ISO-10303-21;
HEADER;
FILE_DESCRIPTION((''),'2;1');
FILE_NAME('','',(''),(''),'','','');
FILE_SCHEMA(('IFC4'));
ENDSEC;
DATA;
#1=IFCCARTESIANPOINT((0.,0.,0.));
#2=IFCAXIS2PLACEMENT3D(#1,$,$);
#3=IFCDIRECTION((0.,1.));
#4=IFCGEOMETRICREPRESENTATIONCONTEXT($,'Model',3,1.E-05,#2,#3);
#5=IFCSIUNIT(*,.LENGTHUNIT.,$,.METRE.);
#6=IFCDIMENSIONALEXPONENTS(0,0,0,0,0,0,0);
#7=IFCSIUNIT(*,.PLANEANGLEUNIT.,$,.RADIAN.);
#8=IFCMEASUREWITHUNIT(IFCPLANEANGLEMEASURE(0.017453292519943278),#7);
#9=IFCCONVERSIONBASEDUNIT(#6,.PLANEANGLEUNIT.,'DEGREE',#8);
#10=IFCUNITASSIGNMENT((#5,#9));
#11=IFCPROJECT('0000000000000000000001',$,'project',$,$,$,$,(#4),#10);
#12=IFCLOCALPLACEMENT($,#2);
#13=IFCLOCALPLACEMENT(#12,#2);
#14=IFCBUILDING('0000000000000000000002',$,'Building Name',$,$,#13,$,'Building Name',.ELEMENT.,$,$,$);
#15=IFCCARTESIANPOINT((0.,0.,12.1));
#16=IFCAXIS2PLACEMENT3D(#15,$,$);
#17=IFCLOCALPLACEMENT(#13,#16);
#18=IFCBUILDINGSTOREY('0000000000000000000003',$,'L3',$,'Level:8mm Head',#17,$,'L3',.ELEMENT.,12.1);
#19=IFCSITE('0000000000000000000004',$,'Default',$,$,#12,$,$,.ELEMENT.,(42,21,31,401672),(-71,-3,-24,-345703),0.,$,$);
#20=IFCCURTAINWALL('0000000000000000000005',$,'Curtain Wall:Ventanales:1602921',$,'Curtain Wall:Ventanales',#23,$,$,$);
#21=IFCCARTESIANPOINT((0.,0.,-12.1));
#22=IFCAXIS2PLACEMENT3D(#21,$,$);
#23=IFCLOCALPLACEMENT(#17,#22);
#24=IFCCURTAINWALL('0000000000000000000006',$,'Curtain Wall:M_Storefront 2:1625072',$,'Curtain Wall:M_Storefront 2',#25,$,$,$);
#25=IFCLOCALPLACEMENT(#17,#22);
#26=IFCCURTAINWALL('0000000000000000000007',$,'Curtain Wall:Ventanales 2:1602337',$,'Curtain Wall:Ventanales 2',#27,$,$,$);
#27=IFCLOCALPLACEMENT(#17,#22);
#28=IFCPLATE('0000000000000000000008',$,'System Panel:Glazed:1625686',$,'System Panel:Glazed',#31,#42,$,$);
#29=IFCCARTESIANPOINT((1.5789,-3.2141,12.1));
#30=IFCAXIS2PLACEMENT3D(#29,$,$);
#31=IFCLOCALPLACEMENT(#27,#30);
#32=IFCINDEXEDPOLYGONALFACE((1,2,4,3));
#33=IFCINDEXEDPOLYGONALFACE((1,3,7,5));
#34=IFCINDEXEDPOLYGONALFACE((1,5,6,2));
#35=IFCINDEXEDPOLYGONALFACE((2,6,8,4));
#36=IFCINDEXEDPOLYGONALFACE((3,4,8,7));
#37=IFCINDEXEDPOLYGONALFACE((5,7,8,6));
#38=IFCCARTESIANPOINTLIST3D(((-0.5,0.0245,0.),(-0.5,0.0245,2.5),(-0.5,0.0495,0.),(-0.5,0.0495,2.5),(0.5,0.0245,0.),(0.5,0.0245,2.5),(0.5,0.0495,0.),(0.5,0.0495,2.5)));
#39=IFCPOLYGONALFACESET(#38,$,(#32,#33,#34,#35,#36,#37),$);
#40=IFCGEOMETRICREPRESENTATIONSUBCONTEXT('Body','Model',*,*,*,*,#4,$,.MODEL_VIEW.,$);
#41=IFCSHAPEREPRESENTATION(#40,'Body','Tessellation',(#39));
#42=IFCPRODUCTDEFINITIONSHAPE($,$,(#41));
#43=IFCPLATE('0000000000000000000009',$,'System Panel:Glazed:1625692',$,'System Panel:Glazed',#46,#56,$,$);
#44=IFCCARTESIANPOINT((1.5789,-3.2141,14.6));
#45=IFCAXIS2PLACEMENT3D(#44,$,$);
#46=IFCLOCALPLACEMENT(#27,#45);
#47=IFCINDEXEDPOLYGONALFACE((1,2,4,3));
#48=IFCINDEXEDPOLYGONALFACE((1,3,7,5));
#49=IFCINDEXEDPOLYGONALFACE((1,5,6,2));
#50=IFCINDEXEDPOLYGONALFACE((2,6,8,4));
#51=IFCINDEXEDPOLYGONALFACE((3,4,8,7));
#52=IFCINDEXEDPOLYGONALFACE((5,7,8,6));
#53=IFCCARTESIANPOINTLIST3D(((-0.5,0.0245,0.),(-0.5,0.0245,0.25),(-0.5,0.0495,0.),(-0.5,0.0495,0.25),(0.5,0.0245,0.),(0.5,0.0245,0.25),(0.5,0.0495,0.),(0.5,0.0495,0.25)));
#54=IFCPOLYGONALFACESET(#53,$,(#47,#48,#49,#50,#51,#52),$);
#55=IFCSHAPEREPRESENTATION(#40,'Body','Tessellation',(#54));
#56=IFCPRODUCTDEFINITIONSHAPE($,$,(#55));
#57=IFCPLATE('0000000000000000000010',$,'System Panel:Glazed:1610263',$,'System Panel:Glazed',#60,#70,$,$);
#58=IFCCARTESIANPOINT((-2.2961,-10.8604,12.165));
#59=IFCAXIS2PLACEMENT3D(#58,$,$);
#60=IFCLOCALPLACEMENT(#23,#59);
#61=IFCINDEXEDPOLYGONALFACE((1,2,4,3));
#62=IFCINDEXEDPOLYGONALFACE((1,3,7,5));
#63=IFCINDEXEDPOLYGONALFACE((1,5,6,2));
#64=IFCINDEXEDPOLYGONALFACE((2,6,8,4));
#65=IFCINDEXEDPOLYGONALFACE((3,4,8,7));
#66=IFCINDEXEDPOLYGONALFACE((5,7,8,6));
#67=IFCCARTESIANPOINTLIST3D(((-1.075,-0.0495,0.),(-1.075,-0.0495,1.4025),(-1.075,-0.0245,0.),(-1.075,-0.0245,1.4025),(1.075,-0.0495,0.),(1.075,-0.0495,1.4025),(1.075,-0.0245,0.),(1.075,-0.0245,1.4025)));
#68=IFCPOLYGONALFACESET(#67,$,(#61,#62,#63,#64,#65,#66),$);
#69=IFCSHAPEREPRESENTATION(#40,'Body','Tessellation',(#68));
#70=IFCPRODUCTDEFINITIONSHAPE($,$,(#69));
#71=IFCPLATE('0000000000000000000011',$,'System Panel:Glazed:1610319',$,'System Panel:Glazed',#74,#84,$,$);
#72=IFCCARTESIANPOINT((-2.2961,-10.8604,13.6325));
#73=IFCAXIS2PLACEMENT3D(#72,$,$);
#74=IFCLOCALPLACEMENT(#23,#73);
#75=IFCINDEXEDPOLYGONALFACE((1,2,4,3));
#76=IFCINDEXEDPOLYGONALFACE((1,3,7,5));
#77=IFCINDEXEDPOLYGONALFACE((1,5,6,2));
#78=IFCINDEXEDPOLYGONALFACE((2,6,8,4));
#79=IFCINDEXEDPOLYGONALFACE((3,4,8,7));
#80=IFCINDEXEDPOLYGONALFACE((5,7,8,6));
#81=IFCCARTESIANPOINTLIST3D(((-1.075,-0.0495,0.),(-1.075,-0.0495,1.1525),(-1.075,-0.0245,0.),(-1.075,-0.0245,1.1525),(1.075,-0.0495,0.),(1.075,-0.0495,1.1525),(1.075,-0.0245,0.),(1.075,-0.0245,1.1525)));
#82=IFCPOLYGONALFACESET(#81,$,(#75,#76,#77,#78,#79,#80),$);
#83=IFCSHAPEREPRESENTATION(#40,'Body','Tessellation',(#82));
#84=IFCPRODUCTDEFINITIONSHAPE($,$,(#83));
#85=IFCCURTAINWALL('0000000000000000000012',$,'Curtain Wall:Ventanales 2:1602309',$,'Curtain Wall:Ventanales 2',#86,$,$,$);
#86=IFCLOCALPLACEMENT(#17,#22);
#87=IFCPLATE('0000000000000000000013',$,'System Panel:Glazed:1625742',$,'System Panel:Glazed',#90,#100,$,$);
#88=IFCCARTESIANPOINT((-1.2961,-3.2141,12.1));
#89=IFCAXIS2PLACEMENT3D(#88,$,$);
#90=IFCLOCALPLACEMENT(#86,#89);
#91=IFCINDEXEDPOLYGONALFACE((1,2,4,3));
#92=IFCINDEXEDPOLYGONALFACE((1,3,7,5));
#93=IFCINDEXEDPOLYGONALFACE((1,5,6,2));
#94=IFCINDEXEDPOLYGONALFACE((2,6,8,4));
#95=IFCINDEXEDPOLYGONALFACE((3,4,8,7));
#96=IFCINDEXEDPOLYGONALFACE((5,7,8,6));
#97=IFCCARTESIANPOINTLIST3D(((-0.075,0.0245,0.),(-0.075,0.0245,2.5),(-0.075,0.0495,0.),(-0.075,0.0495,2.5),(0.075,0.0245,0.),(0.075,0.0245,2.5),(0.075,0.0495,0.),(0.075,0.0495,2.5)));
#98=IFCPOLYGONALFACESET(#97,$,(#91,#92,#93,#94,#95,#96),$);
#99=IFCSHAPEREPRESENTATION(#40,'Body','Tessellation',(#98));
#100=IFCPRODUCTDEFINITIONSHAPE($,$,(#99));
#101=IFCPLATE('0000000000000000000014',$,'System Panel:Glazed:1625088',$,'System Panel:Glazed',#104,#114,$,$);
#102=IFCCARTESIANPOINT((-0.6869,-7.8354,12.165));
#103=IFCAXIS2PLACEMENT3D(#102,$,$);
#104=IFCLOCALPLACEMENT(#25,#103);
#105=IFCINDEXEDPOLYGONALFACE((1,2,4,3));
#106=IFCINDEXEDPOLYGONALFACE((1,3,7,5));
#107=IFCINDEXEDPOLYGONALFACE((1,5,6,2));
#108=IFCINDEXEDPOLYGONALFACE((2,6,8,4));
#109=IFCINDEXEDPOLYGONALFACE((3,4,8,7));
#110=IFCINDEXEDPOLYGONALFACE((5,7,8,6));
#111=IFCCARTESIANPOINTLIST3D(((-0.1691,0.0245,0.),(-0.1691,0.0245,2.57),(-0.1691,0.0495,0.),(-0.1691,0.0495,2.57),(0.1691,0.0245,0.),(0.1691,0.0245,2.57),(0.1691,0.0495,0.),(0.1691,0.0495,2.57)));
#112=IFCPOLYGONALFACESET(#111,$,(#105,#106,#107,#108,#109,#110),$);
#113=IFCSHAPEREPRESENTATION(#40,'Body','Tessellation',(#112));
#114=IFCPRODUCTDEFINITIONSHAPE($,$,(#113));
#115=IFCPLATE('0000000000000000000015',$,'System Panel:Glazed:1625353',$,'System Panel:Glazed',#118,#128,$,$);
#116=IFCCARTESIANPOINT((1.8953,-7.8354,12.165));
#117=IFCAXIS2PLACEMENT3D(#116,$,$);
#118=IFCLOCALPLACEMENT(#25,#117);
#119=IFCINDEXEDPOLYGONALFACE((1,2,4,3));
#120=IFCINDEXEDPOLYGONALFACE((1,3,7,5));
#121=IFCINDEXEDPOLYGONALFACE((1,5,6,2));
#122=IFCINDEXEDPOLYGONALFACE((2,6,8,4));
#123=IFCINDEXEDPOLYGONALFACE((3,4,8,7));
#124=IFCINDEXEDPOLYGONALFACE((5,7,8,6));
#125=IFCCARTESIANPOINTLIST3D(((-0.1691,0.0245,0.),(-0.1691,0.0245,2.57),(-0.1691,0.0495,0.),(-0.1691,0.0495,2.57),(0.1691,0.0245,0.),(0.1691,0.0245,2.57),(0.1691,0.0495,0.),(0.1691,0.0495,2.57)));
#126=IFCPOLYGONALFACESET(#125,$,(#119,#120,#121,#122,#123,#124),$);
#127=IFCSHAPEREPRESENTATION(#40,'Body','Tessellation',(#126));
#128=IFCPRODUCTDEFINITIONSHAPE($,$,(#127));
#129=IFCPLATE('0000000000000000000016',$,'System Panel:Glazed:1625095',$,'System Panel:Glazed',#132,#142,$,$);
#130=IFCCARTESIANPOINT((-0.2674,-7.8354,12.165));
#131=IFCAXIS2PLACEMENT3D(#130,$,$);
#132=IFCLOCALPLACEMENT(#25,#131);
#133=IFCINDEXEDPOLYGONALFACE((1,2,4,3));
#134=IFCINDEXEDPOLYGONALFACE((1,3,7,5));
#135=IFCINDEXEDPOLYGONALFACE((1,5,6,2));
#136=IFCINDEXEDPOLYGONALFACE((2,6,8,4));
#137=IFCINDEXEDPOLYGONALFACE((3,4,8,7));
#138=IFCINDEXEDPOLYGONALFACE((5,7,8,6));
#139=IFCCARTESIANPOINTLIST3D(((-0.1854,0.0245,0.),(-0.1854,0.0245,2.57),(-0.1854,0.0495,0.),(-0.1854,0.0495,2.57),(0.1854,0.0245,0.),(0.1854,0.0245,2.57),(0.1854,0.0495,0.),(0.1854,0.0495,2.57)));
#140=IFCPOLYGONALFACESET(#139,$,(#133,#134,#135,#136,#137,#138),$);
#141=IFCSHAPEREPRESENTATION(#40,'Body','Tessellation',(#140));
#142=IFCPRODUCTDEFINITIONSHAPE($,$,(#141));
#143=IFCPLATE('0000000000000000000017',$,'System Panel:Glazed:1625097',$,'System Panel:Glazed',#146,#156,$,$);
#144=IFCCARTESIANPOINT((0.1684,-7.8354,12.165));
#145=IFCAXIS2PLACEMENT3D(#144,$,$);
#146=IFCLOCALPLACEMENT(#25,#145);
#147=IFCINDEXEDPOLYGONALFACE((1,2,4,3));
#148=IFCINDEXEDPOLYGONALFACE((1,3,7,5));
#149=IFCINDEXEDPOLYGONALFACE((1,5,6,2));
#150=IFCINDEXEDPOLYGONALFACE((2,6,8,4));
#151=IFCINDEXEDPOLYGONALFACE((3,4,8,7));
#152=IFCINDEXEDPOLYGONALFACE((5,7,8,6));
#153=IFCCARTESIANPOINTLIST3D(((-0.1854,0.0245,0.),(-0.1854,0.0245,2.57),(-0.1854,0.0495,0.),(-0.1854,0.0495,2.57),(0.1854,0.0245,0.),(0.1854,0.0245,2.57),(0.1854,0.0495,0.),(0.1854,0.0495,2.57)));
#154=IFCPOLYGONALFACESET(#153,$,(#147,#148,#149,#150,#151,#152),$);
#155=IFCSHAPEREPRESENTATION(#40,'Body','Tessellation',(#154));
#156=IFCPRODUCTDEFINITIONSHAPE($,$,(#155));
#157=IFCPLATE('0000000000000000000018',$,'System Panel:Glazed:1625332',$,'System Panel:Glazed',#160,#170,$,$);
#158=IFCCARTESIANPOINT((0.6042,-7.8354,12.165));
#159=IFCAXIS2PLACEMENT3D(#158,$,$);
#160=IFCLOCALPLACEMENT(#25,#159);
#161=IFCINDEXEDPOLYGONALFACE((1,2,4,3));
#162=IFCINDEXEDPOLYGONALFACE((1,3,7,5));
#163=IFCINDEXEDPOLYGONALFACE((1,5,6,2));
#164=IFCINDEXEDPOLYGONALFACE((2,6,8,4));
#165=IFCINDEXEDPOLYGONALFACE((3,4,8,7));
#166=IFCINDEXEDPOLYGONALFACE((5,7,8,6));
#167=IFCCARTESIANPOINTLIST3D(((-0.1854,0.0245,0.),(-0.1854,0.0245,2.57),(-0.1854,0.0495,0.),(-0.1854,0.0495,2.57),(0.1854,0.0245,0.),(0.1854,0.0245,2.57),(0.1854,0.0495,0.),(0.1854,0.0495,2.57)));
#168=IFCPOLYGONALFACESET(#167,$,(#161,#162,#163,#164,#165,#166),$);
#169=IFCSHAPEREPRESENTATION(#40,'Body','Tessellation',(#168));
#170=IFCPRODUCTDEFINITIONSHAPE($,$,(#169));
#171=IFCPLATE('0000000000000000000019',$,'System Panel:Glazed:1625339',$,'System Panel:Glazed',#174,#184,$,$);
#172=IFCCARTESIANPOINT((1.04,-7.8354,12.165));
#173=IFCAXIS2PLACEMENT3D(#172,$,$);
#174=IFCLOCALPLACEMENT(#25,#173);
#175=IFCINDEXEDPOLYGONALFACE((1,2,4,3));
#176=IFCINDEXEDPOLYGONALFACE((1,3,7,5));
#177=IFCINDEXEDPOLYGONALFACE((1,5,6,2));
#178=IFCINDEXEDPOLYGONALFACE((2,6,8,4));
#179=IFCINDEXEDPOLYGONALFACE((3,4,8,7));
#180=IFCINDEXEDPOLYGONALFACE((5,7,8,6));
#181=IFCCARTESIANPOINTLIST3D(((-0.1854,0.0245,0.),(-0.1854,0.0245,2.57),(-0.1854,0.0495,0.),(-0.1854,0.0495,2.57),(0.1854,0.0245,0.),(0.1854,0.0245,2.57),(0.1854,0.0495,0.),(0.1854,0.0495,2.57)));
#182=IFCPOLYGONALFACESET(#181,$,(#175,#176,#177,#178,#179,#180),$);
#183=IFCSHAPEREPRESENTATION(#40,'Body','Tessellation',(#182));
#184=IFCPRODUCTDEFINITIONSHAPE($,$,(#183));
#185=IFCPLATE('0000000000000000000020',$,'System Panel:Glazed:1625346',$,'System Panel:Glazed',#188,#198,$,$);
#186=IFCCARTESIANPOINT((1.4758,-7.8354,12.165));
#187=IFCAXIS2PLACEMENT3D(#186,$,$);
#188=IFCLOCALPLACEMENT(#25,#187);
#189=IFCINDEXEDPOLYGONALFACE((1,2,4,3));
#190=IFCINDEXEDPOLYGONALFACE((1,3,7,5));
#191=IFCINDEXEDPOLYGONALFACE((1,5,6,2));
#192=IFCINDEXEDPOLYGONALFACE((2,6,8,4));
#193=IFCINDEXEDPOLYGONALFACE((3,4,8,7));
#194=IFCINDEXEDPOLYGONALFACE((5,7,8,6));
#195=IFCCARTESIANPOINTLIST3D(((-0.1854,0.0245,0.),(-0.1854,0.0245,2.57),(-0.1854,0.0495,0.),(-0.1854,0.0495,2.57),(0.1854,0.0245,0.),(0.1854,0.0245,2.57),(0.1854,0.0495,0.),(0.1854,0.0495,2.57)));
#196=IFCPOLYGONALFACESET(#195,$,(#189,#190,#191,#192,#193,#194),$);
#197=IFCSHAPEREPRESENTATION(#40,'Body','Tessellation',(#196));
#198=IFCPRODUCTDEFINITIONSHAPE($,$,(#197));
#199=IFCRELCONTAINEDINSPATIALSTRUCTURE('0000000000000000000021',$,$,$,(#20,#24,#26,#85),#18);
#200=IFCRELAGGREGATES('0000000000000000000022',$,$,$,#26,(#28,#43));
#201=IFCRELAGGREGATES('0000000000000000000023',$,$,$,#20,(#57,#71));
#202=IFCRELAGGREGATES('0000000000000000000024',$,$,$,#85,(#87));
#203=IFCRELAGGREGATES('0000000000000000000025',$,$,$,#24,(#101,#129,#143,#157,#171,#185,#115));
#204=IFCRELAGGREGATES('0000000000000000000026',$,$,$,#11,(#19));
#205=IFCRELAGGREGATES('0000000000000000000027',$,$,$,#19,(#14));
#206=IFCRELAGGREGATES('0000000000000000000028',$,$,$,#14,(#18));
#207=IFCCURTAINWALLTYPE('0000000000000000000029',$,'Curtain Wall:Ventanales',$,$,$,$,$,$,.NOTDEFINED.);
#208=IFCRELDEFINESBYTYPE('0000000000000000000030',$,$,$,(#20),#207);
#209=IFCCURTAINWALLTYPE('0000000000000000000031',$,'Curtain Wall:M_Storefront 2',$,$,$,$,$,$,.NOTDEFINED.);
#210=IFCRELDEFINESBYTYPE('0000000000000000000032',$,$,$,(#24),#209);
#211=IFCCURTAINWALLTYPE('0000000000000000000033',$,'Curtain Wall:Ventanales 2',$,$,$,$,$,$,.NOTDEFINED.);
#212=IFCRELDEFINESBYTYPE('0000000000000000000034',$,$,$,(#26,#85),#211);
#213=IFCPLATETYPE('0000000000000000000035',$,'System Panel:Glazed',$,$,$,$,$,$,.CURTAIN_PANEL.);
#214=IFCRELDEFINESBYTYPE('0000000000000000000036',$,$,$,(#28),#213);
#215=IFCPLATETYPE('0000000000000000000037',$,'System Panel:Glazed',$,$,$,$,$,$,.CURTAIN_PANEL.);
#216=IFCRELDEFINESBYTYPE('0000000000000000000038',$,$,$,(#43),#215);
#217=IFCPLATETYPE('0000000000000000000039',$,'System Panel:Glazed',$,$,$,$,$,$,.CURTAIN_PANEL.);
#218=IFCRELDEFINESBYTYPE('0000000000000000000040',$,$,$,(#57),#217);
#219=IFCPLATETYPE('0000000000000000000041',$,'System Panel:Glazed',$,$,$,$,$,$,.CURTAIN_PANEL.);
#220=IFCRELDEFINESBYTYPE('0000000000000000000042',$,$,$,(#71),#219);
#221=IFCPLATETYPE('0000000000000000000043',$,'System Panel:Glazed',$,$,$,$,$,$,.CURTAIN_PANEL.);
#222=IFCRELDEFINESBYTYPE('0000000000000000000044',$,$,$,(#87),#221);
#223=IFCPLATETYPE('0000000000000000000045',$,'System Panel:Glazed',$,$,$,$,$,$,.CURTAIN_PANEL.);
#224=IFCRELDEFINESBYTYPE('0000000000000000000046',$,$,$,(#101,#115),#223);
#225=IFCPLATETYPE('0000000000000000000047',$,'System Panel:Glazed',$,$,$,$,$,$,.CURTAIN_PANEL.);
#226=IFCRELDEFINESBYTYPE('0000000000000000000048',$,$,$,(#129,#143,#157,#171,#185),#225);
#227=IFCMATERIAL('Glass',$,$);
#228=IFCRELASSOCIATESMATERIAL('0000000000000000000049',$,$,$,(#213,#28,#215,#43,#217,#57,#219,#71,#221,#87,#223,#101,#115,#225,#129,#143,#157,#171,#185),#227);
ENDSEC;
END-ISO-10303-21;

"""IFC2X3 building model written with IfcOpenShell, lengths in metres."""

from ifc_helpers import new_model, entity, si_unit, converted_unit, direction, frame, frame_2d, origin, origin_2d_with_axis, place, context, subcontext, project, spatial, rectangle, extrude, source, transform, mapped, material, type_object, type_shapes, element, aggregate, save


model = new_model("IFC2X3")

# Units and contexts
model_context = context("Model", 3, precision=1e-05, world=origin(), true_north=direction((0.0, 1.0)))
body_context = subcontext(model_context, "Body", "Model", "MODEL_VIEW")
ifc_project = project(units=[si_unit("LENGTHUNIT", "METRE"), converted_unit("PLANEANGLEUNIT", "DEGREE", entity("IfcPlaneAngleMeasure", 0.017453292519943278), si_unit("PLANEANGLEUNIT", "RADIAN"), dimensions=[0, 0, 0, 0, 0, 0, 0])], contexts=[model_context])

# Site, building, storey
site_placement = place(None, origin())
site = spatial("IfcSite", under=ifc_project, at=site_placement, Name="Default", CompositionType="ELEMENT", RefLatitude=(42, 21, 31, 401672), RefLongitude=(-71, -3, -24, -345703), RefElevation=0.0)
building_placement = place(site_placement, origin())
building = spatial("IfcBuilding", under=site, at=building_placement, Name="Building Name", LongName="Building Name", CompositionType="ELEMENT")
storey_placement = place(building_placement, frame((0.0, 0.0, 12.1)))
storey = spatial("IfcBuildingStorey", under=building, at=storey_placement, Name="L3", ObjectType="Level:8mm Head", LongName="L3", CompositionType="ELEMENT", Elevation=12.1)

# Curtain walls
curtain_wall_type_1 = type_object("IfcCurtainWallType", Name="Curtain Wall:Ventanales", PredefinedType="NOTDEFINED")
curtain_wall_1_placement = place(storey_placement, frame((0.0, 0.0, -12.1)))
curtain_wall_1 = element("IfcCurtainWall", 1, at=curtain_wall_1_placement, inside=storey, type_object=curtain_wall_type_1, Name="Curtain Wall:Ventanales:1602921", ObjectType="Curtain Wall:Ventanales")
curtain_wall_type_2 = type_object("IfcCurtainWallType", Name="Curtain Wall:M_Storefront 2", PredefinedType="NOTDEFINED")
curtain_wall_2_placement = place(storey_placement, frame((0.0, 0.0, -12.1)))
curtain_wall_2 = element("IfcCurtainWall", 2, at=curtain_wall_2_placement, inside=storey, type_object=curtain_wall_type_2, Name="Curtain Wall:M_Storefront 2:1625072", ObjectType="Curtain Wall:M_Storefront 2")

# Curtain wall, plates
curtain_wall_type_3 = type_object("IfcCurtainWallType", Name="Curtain Wall:Ventanales 2", PredefinedType="NOTDEFINED")
curtain_wall_3_placement = place(storey_placement, frame((0.0, 0.0, -12.1)))
curtain_wall_3 = element("IfcCurtainWall", 3, at=curtain_wall_3_placement, inside=storey, type_object=curtain_wall_type_3, Name="Curtain Wall:Ventanales 2:1602337", ObjectType="Curtain Wall:Ventanales 2")
ifc_material_1 = material(Name="Glass")
plate_type_1 = type_object("IfcPlateType", Name="System Panel:Glazed", PredefinedType="CURTAIN_PANEL", material=ifc_material_1)
shared_shape_1 = source(origin(), body_context, "Body", "SweptSolid", [
    extrude(rectangle(XDim=0.025, YDim=1.0, at=origin_2d_with_axis()), frame((0.0, 0.037, 0.0), z_axis=(0.0, 0.0, 1.0), x_axis=(0.0, 1.0, 0.0)), (0.0, 0.0, 1.0), 2.5),
])
type_shapes(plate_type_1, [shared_shape_1])
plate_1_placement = place(curtain_wall_3_placement, frame((1.5789, -3.2141, 12.1)))
plate_1 = element("IfcPlate", 4, at=plate_1_placement, type_object=plate_type_1, material=ifc_material_1, Name="System Panel:Glazed:1625686", ObjectType="System Panel:Glazed", context=body_context, shape_type="MappedRepresentation", body=[
    mapped(shared_shape_1, transform((0.0, 0.0, 0.0), scale=1.0)),
])
plate_type_2 = type_object("IfcPlateType", Name="System Panel:Glazed", PredefinedType="CURTAIN_PANEL", material=ifc_material_1)
shared_shape_2 = source(origin(), body_context, "Body", "SweptSolid", [
    extrude(rectangle(XDim=0.025, YDim=1.0, at=origin_2d_with_axis()), frame((0.0, 0.037, 0.0), z_axis=(0.0, 0.0, 1.0), x_axis=(0.0, 1.0, 0.0)), (0.0, 0.0, 1.0), 0.25),
])
type_shapes(plate_type_2, [shared_shape_2])
plate_2_placement = place(curtain_wall_3_placement, frame((1.5789, -3.2141, 14.6)))
plate_2 = element("IfcPlate", 5, at=plate_2_placement, type_object=plate_type_2, material=ifc_material_1, Name="System Panel:Glazed:1625692", ObjectType="System Panel:Glazed", context=body_context, shape_type="MappedRepresentation", body=[
    mapped(shared_shape_2, transform((0.0, 0.0, 0.0), scale=1.0)),
])
aggregate(curtain_wall_3, [plate_1, plate_2])

# Plates
plate_type_3 = type_object("IfcPlateType", Name="System Panel:Glazed", PredefinedType="CURTAIN_PANEL", material=ifc_material_1)
shared_shape_3 = source(origin(), body_context, "Body", "SweptSolid", [
    extrude(rectangle(XDim=0.025, YDim=2.15, at=frame_2d((0.0, 0.0), x_axis=(1.0, 0.0))), frame((0.0, -0.037, 0.0), z_axis=(0.0, 0.0, 1.0), x_axis=(0.0, 1.0, 0.0)), (0.0, 0.0, 1.0), 1.4025),
])
type_shapes(plate_type_3, [shared_shape_3])
plate_3_placement = place(curtain_wall_1_placement, frame((-2.2961, -10.8604, 12.165)))
plate_3 = element("IfcPlate", 6, at=plate_3_placement, type_object=plate_type_3, material=ifc_material_1, Name="System Panel:Glazed:1610263", ObjectType="System Panel:Glazed", context=body_context, shape_type="MappedRepresentation", body=[
    mapped(shared_shape_3, transform((0.0, 0.0, 0.0), scale=1.0)),
])
plate_type_4 = type_object("IfcPlateType", Name="System Panel:Glazed", PredefinedType="CURTAIN_PANEL", material=ifc_material_1)
shared_shape_4 = source(origin(), body_context, "Body", "SweptSolid", [
    extrude(rectangle(XDim=0.025, YDim=2.15, at=frame_2d((0.0, 0.0), x_axis=(1.0, 0.0))), frame((0.0, -0.037, 0.0), z_axis=(0.0, 0.0, 1.0), x_axis=(0.0, 1.0, 0.0)), (0.0, 0.0, 1.0), 1.1525),
])
type_shapes(plate_type_4, [shared_shape_4])
plate_4_placement = place(curtain_wall_1_placement, frame((-2.2961, -10.8604, 13.6325)))
plate_4 = element("IfcPlate", 7, at=plate_4_placement, type_object=plate_type_4, material=ifc_material_1, Name="System Panel:Glazed:1610319", ObjectType="System Panel:Glazed", context=body_context, shape_type="MappedRepresentation", body=[
    mapped(shared_shape_4, transform((0.0, 0.0, 0.0), scale=1.0)),
])
aggregate(curtain_wall_1, [plate_3, plate_4])

# Curtain wall, plate
curtain_wall_4_placement = place(storey_placement, frame((0.0, 0.0, -12.1)))
curtain_wall_4 = element("IfcCurtainWall", 8, at=curtain_wall_4_placement, inside=storey, type_object=curtain_wall_type_3, Name="Curtain Wall:Ventanales 2:1602309", ObjectType="Curtain Wall:Ventanales 2")
plate_type_5 = type_object("IfcPlateType", Name="System Panel:Glazed", PredefinedType="CURTAIN_PANEL", material=ifc_material_1)
shared_shape_5 = source(origin(), body_context, "Body", "SweptSolid", [
    extrude(rectangle(XDim=0.025, YDim=0.15, at=origin_2d_with_axis()), frame((0.0, 0.037, 0.0), z_axis=(0.0, 0.0, 1.0), x_axis=(0.0, 1.0, 0.0)), (0.0, 0.0, 1.0), 2.5),
])
type_shapes(plate_type_5, [shared_shape_5])
plate_5_placement = place(curtain_wall_4_placement, frame((-1.2961, -3.2141, 12.1)))
plate_5 = element("IfcPlate", 9, at=plate_5_placement, type_object=plate_type_5, material=ifc_material_1, Name="System Panel:Glazed:1625742", ObjectType="System Panel:Glazed", context=body_context, shape_type="MappedRepresentation", body=[
    mapped(shared_shape_5, transform((0.0, 0.0, 0.0), scale=1.0)),
])
aggregate(curtain_wall_4, [plate_5])

# Plates
plate_type_6 = type_object("IfcPlateType", Name="System Panel:Glazed", PredefinedType="CURTAIN_PANEL", material=ifc_material_1)
shared_shape_6 = source(origin(), body_context, "Body", "SweptSolid", [
    extrude(rectangle(XDim=0.025, YDim=0.3383, at=origin_2d_with_axis()), frame((0.0, 0.037, 0.0), z_axis=(0.0, 0.0, 1.0), x_axis=(0.0, 1.0, 0.0)), (0.0, 0.0, 1.0), 2.57),
])
type_shapes(plate_type_6, [shared_shape_6])
plate_6_placement = place(curtain_wall_2_placement, frame((-0.6869, -7.8354, 12.165)))
plate_6 = element("IfcPlate", 10, at=plate_6_placement, type_object=plate_type_6, material=ifc_material_1, Name="System Panel:Glazed:1625088", ObjectType="System Panel:Glazed", context=body_context, shape_type="MappedRepresentation", body=[
    mapped(shared_shape_6, transform((0.0, 0.0, 0.0), scale=1.0)),
])
plate_7_placement = place(curtain_wall_2_placement, frame((1.8953, -7.8354, 12.165)))
plate_7 = element("IfcPlate", 11, at=plate_7_placement, type_object=plate_type_6, material=ifc_material_1, Name="System Panel:Glazed:1625353", ObjectType="System Panel:Glazed", context=body_context, shape_type="MappedRepresentation", body=[
    mapped(shared_shape_6, transform((0.0, 0.0, 0.0), scale=1.0)),
])
plate_type_7 = type_object("IfcPlateType", Name="System Panel:Glazed", PredefinedType="CURTAIN_PANEL", material=ifc_material_1)
shared_shape_7 = source(origin(), body_context, "Body", "SweptSolid", [
    extrude(rectangle(XDim=0.025, YDim=0.3708, at=origin_2d_with_axis()), frame((0.0, 0.037, 0.0), z_axis=(0.0, 0.0, 1.0), x_axis=(0.0, 1.0, 0.0)), (0.0, 0.0, 1.0), 2.57),
])
type_shapes(plate_type_7, [shared_shape_7])
plate_8_placement = place(curtain_wall_2_placement, frame((-0.2674, -7.8354, 12.165)))
plate_8 = element("IfcPlate", 12, at=plate_8_placement, type_object=plate_type_7, material=ifc_material_1, Name="System Panel:Glazed:1625095", ObjectType="System Panel:Glazed", context=body_context, shape_type="MappedRepresentation", body=[
    mapped(shared_shape_7, transform((0.0, 0.0, 0.0), scale=1.0)),
])
plate_9_placement = place(curtain_wall_2_placement, frame((0.1684, -7.8354, 12.165)))
plate_9 = element("IfcPlate", 13, at=plate_9_placement, type_object=plate_type_7, material=ifc_material_1, Name="System Panel:Glazed:1625097", ObjectType="System Panel:Glazed", context=body_context, shape_type="MappedRepresentation", body=[
    mapped(shared_shape_7, transform((0.0, 0.0, 0.0), scale=1.0)),
])
plate_10_placement = place(curtain_wall_2_placement, frame((0.6042, -7.8354, 12.165)))
plate_10 = element("IfcPlate", 14, at=plate_10_placement, type_object=plate_type_7, material=ifc_material_1, Name="System Panel:Glazed:1625332", ObjectType="System Panel:Glazed", context=body_context, shape_type="MappedRepresentation", body=[
    mapped(shared_shape_7, transform((0.0, 0.0, 0.0), scale=1.0)),
])
plate_11_placement = place(curtain_wall_2_placement, frame((1.04, -7.8354, 12.165)))
plate_11 = element("IfcPlate", 15, at=plate_11_placement, type_object=plate_type_7, material=ifc_material_1, Name="System Panel:Glazed:1625339", ObjectType="System Panel:Glazed", context=body_context, shape_type="MappedRepresentation", body=[
    mapped(shared_shape_7, transform((0.0, 0.0, 0.0), scale=1.0)),
])
plate_12_placement = place(curtain_wall_2_placement, frame((1.4758, -7.8354, 12.165)))
plate_12 = element("IfcPlate", 16, at=plate_12_placement, type_object=plate_type_7, material=ifc_material_1, Name="System Panel:Glazed:1625346", ObjectType="System Panel:Glazed", context=body_context, shape_type="MappedRepresentation", body=[
    mapped(shared_shape_7, transform((0.0, 0.0, 0.0), scale=1.0)),
])
aggregate(curtain_wall_2, [plate_6, plate_8, plate_9, plate_10, plate_11, plate_12, plate_7])

save(model, "model.ifc")
